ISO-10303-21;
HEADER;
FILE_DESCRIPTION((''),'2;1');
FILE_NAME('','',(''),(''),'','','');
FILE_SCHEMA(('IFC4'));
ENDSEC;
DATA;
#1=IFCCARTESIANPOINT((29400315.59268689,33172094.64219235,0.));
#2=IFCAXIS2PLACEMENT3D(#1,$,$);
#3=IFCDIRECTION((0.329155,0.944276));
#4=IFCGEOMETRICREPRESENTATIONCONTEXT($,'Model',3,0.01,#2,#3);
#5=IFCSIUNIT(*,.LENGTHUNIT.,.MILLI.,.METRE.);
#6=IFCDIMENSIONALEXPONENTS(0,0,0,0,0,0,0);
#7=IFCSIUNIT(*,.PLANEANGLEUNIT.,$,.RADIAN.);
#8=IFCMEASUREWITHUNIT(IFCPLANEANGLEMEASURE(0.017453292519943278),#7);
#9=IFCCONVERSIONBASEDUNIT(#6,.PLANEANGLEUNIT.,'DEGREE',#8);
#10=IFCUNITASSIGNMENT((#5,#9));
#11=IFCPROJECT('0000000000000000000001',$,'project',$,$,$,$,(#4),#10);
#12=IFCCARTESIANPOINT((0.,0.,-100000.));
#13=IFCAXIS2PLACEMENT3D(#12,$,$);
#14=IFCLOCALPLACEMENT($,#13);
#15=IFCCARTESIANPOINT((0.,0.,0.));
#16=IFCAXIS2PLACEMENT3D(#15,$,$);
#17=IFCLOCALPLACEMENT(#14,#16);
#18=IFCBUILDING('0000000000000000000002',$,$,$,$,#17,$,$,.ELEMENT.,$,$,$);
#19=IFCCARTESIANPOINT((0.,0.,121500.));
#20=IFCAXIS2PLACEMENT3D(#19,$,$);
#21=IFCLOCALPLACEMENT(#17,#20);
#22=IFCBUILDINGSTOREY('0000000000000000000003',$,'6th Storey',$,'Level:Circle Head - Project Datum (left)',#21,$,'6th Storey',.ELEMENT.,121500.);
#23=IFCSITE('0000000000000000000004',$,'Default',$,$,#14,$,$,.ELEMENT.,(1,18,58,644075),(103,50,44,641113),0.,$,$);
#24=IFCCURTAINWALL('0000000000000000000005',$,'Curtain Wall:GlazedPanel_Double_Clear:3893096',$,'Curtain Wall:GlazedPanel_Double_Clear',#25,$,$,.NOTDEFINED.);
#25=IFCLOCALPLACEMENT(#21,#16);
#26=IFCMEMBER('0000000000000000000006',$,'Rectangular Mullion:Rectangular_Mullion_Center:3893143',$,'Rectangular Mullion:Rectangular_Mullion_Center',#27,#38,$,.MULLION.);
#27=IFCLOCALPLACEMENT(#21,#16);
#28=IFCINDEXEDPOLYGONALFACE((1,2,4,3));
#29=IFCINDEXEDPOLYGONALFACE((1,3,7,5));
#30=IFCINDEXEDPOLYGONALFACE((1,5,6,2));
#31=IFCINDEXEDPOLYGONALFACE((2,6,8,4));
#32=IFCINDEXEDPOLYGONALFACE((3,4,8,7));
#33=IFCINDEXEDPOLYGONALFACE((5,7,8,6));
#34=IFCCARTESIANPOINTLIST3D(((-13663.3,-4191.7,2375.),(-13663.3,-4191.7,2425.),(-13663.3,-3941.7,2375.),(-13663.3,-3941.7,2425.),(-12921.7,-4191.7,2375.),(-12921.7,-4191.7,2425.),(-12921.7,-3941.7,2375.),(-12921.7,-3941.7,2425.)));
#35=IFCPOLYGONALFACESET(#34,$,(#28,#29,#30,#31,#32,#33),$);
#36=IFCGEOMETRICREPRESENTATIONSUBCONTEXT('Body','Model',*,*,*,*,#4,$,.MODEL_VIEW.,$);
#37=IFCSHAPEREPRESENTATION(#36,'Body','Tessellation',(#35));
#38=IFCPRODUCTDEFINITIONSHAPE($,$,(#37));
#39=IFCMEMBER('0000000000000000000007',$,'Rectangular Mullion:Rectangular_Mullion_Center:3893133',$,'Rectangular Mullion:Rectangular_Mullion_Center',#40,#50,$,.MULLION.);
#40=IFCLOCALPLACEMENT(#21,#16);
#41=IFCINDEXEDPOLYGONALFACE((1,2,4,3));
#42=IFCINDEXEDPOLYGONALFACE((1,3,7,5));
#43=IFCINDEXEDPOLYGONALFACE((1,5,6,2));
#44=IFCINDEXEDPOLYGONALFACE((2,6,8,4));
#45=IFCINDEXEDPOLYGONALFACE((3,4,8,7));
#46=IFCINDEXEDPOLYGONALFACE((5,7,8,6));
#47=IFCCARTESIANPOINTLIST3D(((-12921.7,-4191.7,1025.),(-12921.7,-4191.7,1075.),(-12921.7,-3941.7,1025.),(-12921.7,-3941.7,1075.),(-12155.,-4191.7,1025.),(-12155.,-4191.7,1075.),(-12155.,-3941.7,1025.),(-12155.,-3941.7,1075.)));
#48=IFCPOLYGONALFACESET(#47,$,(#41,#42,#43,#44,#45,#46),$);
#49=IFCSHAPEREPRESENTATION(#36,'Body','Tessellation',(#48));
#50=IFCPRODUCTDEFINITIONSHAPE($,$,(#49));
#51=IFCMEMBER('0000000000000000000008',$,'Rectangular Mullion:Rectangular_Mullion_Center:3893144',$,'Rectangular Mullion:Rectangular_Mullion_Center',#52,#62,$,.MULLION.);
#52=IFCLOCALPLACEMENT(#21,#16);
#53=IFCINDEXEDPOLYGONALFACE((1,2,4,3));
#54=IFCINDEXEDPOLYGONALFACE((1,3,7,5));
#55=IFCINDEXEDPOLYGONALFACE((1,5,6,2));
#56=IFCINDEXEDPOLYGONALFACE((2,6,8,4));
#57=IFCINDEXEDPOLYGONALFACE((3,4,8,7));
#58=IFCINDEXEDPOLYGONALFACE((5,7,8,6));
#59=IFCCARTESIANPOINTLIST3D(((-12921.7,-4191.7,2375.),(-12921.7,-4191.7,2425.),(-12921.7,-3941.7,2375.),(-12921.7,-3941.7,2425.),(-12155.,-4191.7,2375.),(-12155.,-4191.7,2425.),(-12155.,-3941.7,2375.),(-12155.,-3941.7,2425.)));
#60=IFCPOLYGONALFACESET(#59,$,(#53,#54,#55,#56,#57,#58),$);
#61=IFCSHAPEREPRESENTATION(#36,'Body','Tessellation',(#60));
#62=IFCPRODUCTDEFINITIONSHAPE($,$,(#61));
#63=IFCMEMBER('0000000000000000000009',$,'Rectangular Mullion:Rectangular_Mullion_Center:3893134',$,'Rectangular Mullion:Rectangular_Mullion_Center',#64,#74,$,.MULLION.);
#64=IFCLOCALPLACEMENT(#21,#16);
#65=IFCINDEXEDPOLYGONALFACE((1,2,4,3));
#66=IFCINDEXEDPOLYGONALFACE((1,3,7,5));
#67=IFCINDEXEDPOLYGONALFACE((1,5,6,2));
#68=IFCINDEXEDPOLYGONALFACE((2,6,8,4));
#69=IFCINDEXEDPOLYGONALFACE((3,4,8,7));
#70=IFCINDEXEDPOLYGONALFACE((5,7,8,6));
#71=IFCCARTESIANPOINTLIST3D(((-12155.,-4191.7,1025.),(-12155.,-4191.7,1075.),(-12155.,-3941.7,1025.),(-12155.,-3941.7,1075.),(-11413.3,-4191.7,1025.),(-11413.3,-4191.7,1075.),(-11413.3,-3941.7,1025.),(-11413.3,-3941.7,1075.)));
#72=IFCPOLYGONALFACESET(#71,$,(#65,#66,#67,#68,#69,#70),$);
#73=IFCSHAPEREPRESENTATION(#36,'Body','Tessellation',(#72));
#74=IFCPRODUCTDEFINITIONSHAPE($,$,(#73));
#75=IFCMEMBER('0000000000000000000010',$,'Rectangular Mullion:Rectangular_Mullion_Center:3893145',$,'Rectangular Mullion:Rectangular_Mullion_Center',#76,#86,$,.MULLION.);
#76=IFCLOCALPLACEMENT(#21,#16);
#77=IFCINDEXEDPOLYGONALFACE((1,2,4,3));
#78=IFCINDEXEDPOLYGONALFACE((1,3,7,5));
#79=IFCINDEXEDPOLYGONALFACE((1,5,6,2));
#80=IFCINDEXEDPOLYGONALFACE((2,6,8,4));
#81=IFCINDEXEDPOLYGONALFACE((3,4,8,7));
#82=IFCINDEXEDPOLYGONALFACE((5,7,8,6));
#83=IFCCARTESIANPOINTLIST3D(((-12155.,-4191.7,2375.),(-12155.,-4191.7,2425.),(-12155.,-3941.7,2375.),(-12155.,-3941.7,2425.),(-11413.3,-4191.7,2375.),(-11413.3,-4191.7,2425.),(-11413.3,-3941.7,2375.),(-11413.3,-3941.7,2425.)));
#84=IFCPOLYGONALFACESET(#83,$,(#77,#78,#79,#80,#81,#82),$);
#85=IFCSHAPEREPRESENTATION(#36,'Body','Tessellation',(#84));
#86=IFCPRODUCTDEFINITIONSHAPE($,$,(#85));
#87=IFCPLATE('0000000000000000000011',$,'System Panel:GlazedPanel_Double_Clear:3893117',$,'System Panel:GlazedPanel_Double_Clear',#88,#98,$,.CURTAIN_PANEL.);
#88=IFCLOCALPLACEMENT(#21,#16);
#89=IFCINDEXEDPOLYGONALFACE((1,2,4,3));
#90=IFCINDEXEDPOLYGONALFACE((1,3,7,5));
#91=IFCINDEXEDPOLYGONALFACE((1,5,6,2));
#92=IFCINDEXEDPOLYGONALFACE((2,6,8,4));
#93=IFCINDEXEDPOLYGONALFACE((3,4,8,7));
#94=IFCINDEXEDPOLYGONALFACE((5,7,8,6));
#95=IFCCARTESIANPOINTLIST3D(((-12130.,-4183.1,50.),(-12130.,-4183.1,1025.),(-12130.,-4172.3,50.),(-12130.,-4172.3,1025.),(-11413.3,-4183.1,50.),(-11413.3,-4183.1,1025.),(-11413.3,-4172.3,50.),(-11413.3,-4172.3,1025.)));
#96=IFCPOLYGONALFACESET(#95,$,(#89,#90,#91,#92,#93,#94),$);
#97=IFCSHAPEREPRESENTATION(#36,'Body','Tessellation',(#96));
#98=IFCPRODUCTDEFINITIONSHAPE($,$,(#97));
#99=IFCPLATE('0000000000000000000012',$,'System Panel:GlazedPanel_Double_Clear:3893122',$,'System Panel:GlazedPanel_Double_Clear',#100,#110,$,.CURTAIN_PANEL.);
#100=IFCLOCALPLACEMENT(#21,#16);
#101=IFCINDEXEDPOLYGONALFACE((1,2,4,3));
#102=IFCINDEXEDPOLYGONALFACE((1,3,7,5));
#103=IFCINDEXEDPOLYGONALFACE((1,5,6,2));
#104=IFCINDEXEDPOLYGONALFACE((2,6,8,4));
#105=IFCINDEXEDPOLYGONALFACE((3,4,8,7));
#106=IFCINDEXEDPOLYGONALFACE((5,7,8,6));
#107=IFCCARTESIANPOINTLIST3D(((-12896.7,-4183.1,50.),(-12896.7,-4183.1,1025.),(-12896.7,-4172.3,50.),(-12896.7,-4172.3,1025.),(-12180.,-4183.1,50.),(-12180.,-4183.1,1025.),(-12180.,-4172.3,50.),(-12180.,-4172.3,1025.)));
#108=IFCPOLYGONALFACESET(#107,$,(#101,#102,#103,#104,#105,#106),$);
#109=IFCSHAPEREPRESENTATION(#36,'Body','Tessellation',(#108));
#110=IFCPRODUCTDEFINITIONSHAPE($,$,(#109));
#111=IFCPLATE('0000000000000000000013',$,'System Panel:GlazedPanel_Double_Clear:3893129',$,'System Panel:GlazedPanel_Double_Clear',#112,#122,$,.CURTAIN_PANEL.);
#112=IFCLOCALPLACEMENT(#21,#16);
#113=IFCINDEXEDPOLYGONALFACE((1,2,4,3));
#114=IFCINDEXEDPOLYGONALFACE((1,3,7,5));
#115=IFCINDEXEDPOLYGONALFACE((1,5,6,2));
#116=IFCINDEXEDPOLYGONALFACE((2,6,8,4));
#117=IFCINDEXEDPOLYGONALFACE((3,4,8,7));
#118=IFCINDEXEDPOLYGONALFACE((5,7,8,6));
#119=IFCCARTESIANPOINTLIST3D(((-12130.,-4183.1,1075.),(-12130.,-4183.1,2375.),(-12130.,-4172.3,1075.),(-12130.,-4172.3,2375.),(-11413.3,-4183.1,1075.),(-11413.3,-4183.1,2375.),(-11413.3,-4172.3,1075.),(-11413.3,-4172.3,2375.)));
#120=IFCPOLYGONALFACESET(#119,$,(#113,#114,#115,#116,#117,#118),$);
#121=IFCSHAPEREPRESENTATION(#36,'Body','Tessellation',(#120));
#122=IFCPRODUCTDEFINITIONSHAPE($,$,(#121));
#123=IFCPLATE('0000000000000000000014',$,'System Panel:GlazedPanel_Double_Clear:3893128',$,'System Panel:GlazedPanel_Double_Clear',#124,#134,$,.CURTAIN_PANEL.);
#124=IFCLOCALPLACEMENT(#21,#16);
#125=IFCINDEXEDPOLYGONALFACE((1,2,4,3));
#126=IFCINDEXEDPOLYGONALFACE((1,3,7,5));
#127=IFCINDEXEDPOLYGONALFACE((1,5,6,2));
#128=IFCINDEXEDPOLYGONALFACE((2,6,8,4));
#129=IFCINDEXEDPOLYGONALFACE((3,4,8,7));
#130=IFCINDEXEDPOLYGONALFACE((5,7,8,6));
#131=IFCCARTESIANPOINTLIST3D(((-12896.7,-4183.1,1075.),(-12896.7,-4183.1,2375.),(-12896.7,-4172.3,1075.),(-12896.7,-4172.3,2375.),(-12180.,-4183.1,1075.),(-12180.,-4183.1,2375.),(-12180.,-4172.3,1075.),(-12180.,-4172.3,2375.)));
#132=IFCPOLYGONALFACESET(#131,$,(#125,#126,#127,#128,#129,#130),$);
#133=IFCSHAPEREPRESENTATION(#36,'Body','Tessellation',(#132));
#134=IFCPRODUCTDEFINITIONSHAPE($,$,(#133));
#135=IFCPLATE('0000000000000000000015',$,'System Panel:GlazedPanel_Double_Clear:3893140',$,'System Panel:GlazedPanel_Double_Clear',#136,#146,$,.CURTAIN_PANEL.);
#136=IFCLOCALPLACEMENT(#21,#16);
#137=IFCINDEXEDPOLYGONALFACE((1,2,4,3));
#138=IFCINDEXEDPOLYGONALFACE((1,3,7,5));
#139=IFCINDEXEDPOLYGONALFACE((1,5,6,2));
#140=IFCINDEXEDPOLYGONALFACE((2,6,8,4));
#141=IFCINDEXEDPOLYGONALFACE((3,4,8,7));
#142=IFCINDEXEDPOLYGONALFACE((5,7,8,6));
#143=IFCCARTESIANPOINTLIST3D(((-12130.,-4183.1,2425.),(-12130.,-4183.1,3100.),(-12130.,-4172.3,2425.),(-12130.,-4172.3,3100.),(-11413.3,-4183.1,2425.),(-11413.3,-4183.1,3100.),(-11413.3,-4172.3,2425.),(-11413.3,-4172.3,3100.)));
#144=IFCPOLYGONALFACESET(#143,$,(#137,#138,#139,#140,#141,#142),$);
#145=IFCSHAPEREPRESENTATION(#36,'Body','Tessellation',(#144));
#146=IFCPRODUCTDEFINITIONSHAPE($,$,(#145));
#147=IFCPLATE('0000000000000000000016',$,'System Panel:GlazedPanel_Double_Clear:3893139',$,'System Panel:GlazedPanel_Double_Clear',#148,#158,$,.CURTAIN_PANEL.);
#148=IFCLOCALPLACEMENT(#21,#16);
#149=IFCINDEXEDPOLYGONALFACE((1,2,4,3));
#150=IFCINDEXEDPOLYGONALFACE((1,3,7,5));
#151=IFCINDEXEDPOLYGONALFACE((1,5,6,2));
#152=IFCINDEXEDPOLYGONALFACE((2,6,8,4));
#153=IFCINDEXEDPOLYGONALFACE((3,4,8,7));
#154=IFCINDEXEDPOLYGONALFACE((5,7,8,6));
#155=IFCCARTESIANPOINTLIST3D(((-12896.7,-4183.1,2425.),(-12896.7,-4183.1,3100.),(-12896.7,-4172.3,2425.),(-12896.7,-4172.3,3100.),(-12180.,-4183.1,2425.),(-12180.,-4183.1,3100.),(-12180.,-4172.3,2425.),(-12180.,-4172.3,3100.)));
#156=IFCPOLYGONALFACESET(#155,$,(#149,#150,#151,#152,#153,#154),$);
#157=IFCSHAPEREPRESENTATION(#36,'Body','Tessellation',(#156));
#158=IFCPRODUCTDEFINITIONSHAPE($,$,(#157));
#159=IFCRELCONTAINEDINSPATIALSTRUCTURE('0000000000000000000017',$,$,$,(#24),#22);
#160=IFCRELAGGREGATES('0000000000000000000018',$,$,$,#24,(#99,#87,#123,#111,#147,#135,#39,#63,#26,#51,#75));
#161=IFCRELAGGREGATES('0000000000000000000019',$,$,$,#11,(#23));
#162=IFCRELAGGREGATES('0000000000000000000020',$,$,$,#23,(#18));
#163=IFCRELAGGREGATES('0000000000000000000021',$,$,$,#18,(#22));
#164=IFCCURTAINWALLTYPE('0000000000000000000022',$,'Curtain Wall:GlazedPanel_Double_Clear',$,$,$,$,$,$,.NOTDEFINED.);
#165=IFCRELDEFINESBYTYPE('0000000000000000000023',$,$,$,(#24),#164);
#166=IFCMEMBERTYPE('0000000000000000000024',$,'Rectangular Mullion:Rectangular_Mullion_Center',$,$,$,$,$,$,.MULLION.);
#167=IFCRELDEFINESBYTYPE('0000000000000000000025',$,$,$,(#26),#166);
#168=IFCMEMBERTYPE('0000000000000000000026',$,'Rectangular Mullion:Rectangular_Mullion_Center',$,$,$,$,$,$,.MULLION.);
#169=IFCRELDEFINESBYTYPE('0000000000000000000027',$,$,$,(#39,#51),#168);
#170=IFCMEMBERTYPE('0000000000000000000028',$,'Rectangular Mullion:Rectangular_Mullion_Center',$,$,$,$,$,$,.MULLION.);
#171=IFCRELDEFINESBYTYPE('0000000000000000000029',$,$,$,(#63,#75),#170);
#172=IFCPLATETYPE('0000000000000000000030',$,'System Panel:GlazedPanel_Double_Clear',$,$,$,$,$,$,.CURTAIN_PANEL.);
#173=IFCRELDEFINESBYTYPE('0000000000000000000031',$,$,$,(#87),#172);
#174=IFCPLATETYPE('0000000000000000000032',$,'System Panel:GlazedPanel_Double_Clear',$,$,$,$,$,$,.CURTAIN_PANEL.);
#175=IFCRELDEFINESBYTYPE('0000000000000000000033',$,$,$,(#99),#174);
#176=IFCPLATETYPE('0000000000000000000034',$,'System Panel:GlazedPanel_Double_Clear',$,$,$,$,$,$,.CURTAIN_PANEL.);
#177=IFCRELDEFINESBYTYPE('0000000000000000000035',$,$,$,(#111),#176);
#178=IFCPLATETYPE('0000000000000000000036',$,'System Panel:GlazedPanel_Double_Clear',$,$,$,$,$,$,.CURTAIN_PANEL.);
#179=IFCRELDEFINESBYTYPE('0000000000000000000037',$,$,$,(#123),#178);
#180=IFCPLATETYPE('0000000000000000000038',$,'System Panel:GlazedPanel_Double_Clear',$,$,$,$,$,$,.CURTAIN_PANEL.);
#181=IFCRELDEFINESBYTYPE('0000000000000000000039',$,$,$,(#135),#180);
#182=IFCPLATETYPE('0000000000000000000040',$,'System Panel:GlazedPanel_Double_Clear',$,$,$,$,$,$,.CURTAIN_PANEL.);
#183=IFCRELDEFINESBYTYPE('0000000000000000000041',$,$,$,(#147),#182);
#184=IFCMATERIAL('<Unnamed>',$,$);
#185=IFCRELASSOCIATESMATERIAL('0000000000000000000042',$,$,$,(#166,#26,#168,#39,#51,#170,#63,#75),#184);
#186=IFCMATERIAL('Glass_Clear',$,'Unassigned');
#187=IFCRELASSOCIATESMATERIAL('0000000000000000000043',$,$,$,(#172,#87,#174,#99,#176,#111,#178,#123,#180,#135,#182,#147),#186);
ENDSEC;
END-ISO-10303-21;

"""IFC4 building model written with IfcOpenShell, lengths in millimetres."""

from ifc_helpers import new_model, entity, si_unit, converted_unit, direction, frame, origin, place, context, subcontext, project, spatial, indexed_curve, outline, extrude, source, transform, mapped, material, type_object, type_shapes, element, aggregate, save


model = new_model("IFC4")

# Units and contexts
model_context = context("Model", 3, precision=0.01, world=frame((29400315.59268689, 33172094.64219235, 0.0)), true_north=direction((0.329155, 0.944276)))
body_context = subcontext(model_context, "Body", "Model", "MODEL_VIEW")
ifc_project = project(units=[si_unit("LENGTHUNIT", "METRE", prefix="MILLI"), converted_unit("PLANEANGLEUNIT", "DEGREE", entity("IfcPlaneAngleMeasure", 0.017453292519943278), si_unit("PLANEANGLEUNIT", "RADIAN"), dimensions=[0, 0, 0, 0, 0, 0, 0])], contexts=[model_context])

# Site, building, storey
site_placement = place(None, frame((0.0, 0.0, -100000.0)))
site = spatial("IfcSite", under=ifc_project, at=site_placement, Name="Default", CompositionType="ELEMENT", RefLatitude=(1, 18, 58, 644075), RefLongitude=(103, 50, 44, 641113), RefElevation=0.0)
building_placement = place(site_placement, origin())
building = spatial("IfcBuilding", under=site, at=building_placement, CompositionType="ELEMENT")
storey_placement = place(building_placement, frame((0.0, 0.0, 121500.0)))
storey = spatial("IfcBuildingStorey", under=building, at=storey_placement, Name="6th Storey", ObjectType="Level:Circle Head - Project Datum (left)", LongName="6th Storey", CompositionType="ELEMENT", Elevation=121500.0)

# Curtain wall, members, plates
curtain_wall_type = type_object("IfcCurtainWallType", Name="Curtain Wall:GlazedPanel_Double_Clear", PredefinedType="NOTDEFINED")
curtain_wall_1_placement = place(storey_placement, frame((0.0, 0.0, -121500.0)))
curtain_wall_1 = element("IfcCurtainWall", 1, at=curtain_wall_1_placement, inside=storey, type_object=curtain_wall_type, Name="Curtain Wall:GlazedPanel_Double_Clear:3893096", ObjectType="Curtain Wall:GlazedPanel_Double_Clear", PredefinedType="NOTDEFINED")
ifc_material_1 = material(Name="<Unnamed>")
member_type_1 = type_object("IfcMemberType", Name="Rectangular Mullion:Rectangular_Mullion_Center", PredefinedType="MULLION", material=ifc_material_1)
shared_shape_1 = source(origin(), body_context, "Body", "SweptSolid", [
    extrude(outline(indexed_curve([(-25.0, -125.0), (25.0, -125.0), (25.0, 125.0), (-25.0, 125.0), (-25.0, -125.0)], self_intersect=False)), frame((0.0, 0.0, -741.7), z_axis=(0.0, 0.0, 1.0), x_axis=(-1.0, 0.0, 0.0)), (0.0, 0.0, 1.0), 741.7),
])
type_shapes(member_type_1, [shared_shape_1])
member_1_placement = place(curtain_wall_1_placement, frame((-12921.7, -4066.7, 123900.0), z_axis=(1.0, 0.0, 0.0), x_axis=(0.0, 0.0, 1.0)))
member_1 = element("IfcMember", 2, at=member_1_placement, type_object=member_type_1, material=ifc_material_1, Name="Rectangular Mullion:Rectangular_Mullion_Center:3893143", ObjectType="Rectangular Mullion:Rectangular_Mullion_Center", PredefinedType="MULLION", context=body_context, shape_type="MappedRepresentation", body=[
    mapped(shared_shape_1, transform((0.0, 0.0, 0.0), scale=1.0)),
])
member_type_2 = type_object("IfcMemberType", Name="Rectangular Mullion:Rectangular_Mullion_Center", PredefinedType="MULLION", material=ifc_material_1)
shared_shape_2 = source(origin(), body_context, "Body", "SweptSolid", [
    extrude(outline(indexed_curve([(-25.0, -125.0), (25.0, -125.0), (25.0, 125.0), (-25.0, 125.0), (-25.0, -125.0)], self_intersect=False)), frame((0.0, 0.0, -766.7), z_axis=(0.0, 0.0, 1.0), x_axis=(-1.0, 0.0, 0.0)), (0.0, 0.0, 1.0), 766.7),
])
type_shapes(member_type_2, [shared_shape_2])
member_2_placement = place(curtain_wall_1_placement, frame((-12155.0, -4066.7, 122550.0), z_axis=(1.0, 0.0, 0.0), x_axis=(0.0, 0.0, 1.0)))
member_2 = element("IfcMember", 3, at=member_2_placement, type_object=member_type_2, material=ifc_material_1, Name="Rectangular Mullion:Rectangular_Mullion_Center:3893133", ObjectType="Rectangular Mullion:Rectangular_Mullion_Center", PredefinedType="MULLION", context=body_context, shape_type="MappedRepresentation", body=[
    mapped(shared_shape_2, transform((0.0, 0.0, 0.0), scale=1.0)),
])
member_3_placement = place(curtain_wall_1_placement, frame((-12155.0, -4066.7, 123900.0), z_axis=(1.0, 0.0, 0.0), x_axis=(0.0, 0.0, 1.0)))
member_3 = element("IfcMember", 4, at=member_3_placement, type_object=member_type_2, material=ifc_material_1, Name="Rectangular Mullion:Rectangular_Mullion_Center:3893144", ObjectType="Rectangular Mullion:Rectangular_Mullion_Center", PredefinedType="MULLION", context=body_context, shape_type="MappedRepresentation", body=[
    mapped(shared_shape_2, transform((0.0, 0.0, 0.0), scale=1.0)),
])
member_type_3 = type_object("IfcMemberType", Name="Rectangular Mullion:Rectangular_Mullion_Center", PredefinedType="MULLION", material=ifc_material_1)
shared_shape_3 = source(origin(), body_context, "Body", "SweptSolid", [
    extrude(outline(indexed_curve([(-25.0, -125.0), (25.0, -125.0), (25.0, 125.0), (-25.0, 125.0), (-25.0, -125.0)], self_intersect=False)), frame((0.0, 0.0, -741.7), z_axis=(0.0, 0.0, 1.0), x_axis=(-1.0, 0.0, 0.0)), (0.0, 0.0, 1.0), 741.7),
])
type_shapes(member_type_3, [shared_shape_3])
member_4_placement = place(curtain_wall_1_placement, frame((-11413.3, -4066.7, 122550.0), z_axis=(1.0, 0.0, 0.0), x_axis=(0.0, 0.0, 1.0)))
member_4 = element("IfcMember", 5, at=member_4_placement, type_object=member_type_3, material=ifc_material_1, Name="Rectangular Mullion:Rectangular_Mullion_Center:3893134", ObjectType="Rectangular Mullion:Rectangular_Mullion_Center", PredefinedType="MULLION", context=body_context, shape_type="MappedRepresentation", body=[
    mapped(shared_shape_3, transform((0.0, 0.0, 0.0), scale=1.0)),
])
member_5_placement = place(curtain_wall_1_placement, frame((-11413.3, -4066.7, 123900.0), z_axis=(1.0, 0.0, 0.0), x_axis=(0.0, 0.0, 1.0)))
member_5 = element("IfcMember", 6, at=member_5_placement, type_object=member_type_3, material=ifc_material_1, Name="Rectangular Mullion:Rectangular_Mullion_Center:3893145", ObjectType="Rectangular Mullion:Rectangular_Mullion_Center", PredefinedType="MULLION", context=body_context, shape_type="MappedRepresentation", body=[
    mapped(shared_shape_3, transform((0.0, 0.0, 0.0), scale=1.0)),
])
ifc_material_2 = material(Name="Glass_Clear", Category="Unassigned")
plate_type_1 = type_object("IfcPlateType", Name="System Panel:GlazedPanel_Double_Clear", PredefinedType="CURTAIN_PANEL", material=ifc_material_2)
shared_shape_4 = source(origin(), body_context, "Body", "SweptSolid", [
    extrude(outline(indexed_curve([(-5.4, -358.3), (5.4, -358.3), (5.4, 358.3), (-5.4, 358.3), (-5.4, -358.3)], self_intersect=False)), frame((0.0, -111.0, 0.0), z_axis=(0.0, 0.0, 1.0), x_axis=(0.0, 1.0, 0.0)), (0.0, 0.0, 1.0), 975.0),
])
type_shapes(plate_type_1, [shared_shape_4])
plate_1_placement = place(curtain_wall_1_placement, frame((-11771.7, -4066.7, 121550.0)))
plate_1 = element("IfcPlate", 7, at=plate_1_placement, type_object=plate_type_1, material=ifc_material_2, Name="System Panel:GlazedPanel_Double_Clear:3893117", ObjectType="System Panel:GlazedPanel_Double_Clear", PredefinedType="CURTAIN_PANEL", context=body_context, shape_type="MappedRepresentation", body=[
    mapped(shared_shape_4, transform((0.0, 0.0, 0.0), scale=1.0)),
])
plate_type_2 = type_object("IfcPlateType", Name="System Panel:GlazedPanel_Double_Clear", PredefinedType="CURTAIN_PANEL", material=ifc_material_2)
shared_shape_5 = source(origin(), body_context, "Body", "SweptSolid", [
    extrude(outline(indexed_curve([(-5.4, -358.3), (5.4, -358.3), (5.4, 358.3), (-5.4, 358.3), (-5.4, -358.3)], self_intersect=False)), frame((0.0, -111.0, 0.0), z_axis=(0.0, 0.0, 1.0), x_axis=(0.0, 1.0, 0.0)), (0.0, 0.0, 1.0), 975.0),
])
type_shapes(plate_type_2, [shared_shape_5])
plate_2_placement = place(curtain_wall_1_placement, frame((-12538.3, -4066.7, 121550.0)))
plate_2 = element("IfcPlate", 8, at=plate_2_placement, type_object=plate_type_2, material=ifc_material_2, Name="System Panel:GlazedPanel_Double_Clear:3893122", ObjectType="System Panel:GlazedPanel_Double_Clear", PredefinedType="CURTAIN_PANEL", context=body_context, shape_type="MappedRepresentation", body=[
    mapped(shared_shape_5, transform((0.0, 0.0, 0.0), scale=1.0)),
])
plate_type_3 = type_object("IfcPlateType", Name="System Panel:GlazedPanel_Double_Clear", PredefinedType="CURTAIN_PANEL", material=ifc_material_2)
shared_shape_6 = source(origin(), body_context, "Body", "SweptSolid", [
    extrude(outline(indexed_curve([(-5.4, -358.3), (5.4, -358.3), (5.4, 358.3), (-5.4, 358.3), (-5.4, -358.3)], self_intersect=False)), frame((0.0, -111.0, 0.0), z_axis=(0.0, 0.0, 1.0), x_axis=(0.0, 1.0, 0.0)), (0.0, 0.0, 1.0), 1300.0),
])
type_shapes(plate_type_3, [shared_shape_6])
plate_3_placement = place(curtain_wall_1_placement, frame((-11771.7, -4066.7, 122575.0)))
plate_3 = element("IfcPlate", 9, at=plate_3_placement, type_object=plate_type_3, material=ifc_material_2, Name="System Panel:GlazedPanel_Double_Clear:3893129", ObjectType="System Panel:GlazedPanel_Double_Clear", PredefinedType="CURTAIN_PANEL", context=body_context, shape_type="MappedRepresentation", body=[
    mapped(shared_shape_6, transform((0.0, 0.0, 0.0), scale=1.0)),
])
plate_type_4 = type_object("IfcPlateType", Name="System Panel:GlazedPanel_Double_Clear", PredefinedType="CURTAIN_PANEL", material=ifc_material_2)
shared_shape_7 = source(origin(), body_context, "Body", "SweptSolid", [
    extrude(outline(indexed_curve([(-5.4, -358.3), (5.4, -358.3), (5.4, 358.3), (-5.4, 358.3), (-5.4, -358.3)], self_intersect=False)), frame((0.0, -111.0, 0.0), z_axis=(0.0, 0.0, 1.0), x_axis=(0.0, 1.0, 0.0)), (0.0, 0.0, 1.0), 1300.0),
])
type_shapes(plate_type_4, [shared_shape_7])
plate_4_placement = place(curtain_wall_1_placement, frame((-12538.3, -4066.7, 122575.0)))
plate_4 = element("IfcPlate", 10, at=plate_4_placement, type_object=plate_type_4, material=ifc_material_2, Name="System Panel:GlazedPanel_Double_Clear:3893128", ObjectType="System Panel:GlazedPanel_Double_Clear", PredefinedType="CURTAIN_PANEL", context=body_context, shape_type="MappedRepresentation", body=[
    mapped(shared_shape_7, transform((0.0, 0.0, 0.0), scale=1.0)),
])
plate_type_5 = type_object("IfcPlateType", Name="System Panel:GlazedPanel_Double_Clear", PredefinedType="CURTAIN_PANEL", material=ifc_material_2)
shared_shape_8 = source(origin(), body_context, "Body", "SweptSolid", [
    extrude(outline(indexed_curve([(-5.4, -358.3), (5.4, -358.3), (5.4, 358.3), (-5.4, 358.3), (-5.4, -358.3)], self_intersect=False)), frame((0.0, -111.0, 0.0), z_axis=(0.0, 0.0, 1.0), x_axis=(0.0, 1.0, 0.0)), (0.0, 0.0, 1.0), 675.0),
])
type_shapes(plate_type_5, [shared_shape_8])
plate_5_placement = place(curtain_wall_1_placement, frame((-11771.7, -4066.7, 123925.0)))
plate_5 = element("IfcPlate", 11, at=plate_5_placement, type_object=plate_type_5, material=ifc_material_2, Name="System Panel:GlazedPanel_Double_Clear:3893140", ObjectType="System Panel:GlazedPanel_Double_Clear", PredefinedType="CURTAIN_PANEL", context=body_context, shape_type="MappedRepresentation", body=[
    mapped(shared_shape_8, transform((0.0, 0.0, 0.0), scale=1.0)),
])
plate_type_6 = type_object("IfcPlateType", Name="System Panel:GlazedPanel_Double_Clear", PredefinedType="CURTAIN_PANEL", material=ifc_material_2)
shared_shape_9 = source(origin(), body_context, "Body", "SweptSolid", [
    extrude(outline(indexed_curve([(-5.4, -358.3), (5.4, -358.3), (5.4, 358.3), (-5.4, 358.3), (-5.4, -358.3)], self_intersect=False)), frame((0.0, -111.0, 0.0), z_axis=(0.0, 0.0, 1.0), x_axis=(0.0, 1.0, 0.0)), (0.0, 0.0, 1.0), 675.0),
])
type_shapes(plate_type_6, [shared_shape_9])
plate_6_placement = place(curtain_wall_1_placement, frame((-12538.3, -4066.7, 123925.0)))
plate_6 = element("IfcPlate", 12, at=plate_6_placement, type_object=plate_type_6, material=ifc_material_2, Name="System Panel:GlazedPanel_Double_Clear:3893139", ObjectType="System Panel:GlazedPanel_Double_Clear", PredefinedType="CURTAIN_PANEL", context=body_context, shape_type="MappedRepresentation", body=[
    mapped(shared_shape_9, transform((0.0, 0.0, 0.0), scale=1.0)),
])
aggregate(curtain_wall_1, [plate_2, plate_1, plate_4, plate_3, plate_6, plate_5, member_2, member_4, member_1, member_3, member_5])

save(model, "model.ifc")
